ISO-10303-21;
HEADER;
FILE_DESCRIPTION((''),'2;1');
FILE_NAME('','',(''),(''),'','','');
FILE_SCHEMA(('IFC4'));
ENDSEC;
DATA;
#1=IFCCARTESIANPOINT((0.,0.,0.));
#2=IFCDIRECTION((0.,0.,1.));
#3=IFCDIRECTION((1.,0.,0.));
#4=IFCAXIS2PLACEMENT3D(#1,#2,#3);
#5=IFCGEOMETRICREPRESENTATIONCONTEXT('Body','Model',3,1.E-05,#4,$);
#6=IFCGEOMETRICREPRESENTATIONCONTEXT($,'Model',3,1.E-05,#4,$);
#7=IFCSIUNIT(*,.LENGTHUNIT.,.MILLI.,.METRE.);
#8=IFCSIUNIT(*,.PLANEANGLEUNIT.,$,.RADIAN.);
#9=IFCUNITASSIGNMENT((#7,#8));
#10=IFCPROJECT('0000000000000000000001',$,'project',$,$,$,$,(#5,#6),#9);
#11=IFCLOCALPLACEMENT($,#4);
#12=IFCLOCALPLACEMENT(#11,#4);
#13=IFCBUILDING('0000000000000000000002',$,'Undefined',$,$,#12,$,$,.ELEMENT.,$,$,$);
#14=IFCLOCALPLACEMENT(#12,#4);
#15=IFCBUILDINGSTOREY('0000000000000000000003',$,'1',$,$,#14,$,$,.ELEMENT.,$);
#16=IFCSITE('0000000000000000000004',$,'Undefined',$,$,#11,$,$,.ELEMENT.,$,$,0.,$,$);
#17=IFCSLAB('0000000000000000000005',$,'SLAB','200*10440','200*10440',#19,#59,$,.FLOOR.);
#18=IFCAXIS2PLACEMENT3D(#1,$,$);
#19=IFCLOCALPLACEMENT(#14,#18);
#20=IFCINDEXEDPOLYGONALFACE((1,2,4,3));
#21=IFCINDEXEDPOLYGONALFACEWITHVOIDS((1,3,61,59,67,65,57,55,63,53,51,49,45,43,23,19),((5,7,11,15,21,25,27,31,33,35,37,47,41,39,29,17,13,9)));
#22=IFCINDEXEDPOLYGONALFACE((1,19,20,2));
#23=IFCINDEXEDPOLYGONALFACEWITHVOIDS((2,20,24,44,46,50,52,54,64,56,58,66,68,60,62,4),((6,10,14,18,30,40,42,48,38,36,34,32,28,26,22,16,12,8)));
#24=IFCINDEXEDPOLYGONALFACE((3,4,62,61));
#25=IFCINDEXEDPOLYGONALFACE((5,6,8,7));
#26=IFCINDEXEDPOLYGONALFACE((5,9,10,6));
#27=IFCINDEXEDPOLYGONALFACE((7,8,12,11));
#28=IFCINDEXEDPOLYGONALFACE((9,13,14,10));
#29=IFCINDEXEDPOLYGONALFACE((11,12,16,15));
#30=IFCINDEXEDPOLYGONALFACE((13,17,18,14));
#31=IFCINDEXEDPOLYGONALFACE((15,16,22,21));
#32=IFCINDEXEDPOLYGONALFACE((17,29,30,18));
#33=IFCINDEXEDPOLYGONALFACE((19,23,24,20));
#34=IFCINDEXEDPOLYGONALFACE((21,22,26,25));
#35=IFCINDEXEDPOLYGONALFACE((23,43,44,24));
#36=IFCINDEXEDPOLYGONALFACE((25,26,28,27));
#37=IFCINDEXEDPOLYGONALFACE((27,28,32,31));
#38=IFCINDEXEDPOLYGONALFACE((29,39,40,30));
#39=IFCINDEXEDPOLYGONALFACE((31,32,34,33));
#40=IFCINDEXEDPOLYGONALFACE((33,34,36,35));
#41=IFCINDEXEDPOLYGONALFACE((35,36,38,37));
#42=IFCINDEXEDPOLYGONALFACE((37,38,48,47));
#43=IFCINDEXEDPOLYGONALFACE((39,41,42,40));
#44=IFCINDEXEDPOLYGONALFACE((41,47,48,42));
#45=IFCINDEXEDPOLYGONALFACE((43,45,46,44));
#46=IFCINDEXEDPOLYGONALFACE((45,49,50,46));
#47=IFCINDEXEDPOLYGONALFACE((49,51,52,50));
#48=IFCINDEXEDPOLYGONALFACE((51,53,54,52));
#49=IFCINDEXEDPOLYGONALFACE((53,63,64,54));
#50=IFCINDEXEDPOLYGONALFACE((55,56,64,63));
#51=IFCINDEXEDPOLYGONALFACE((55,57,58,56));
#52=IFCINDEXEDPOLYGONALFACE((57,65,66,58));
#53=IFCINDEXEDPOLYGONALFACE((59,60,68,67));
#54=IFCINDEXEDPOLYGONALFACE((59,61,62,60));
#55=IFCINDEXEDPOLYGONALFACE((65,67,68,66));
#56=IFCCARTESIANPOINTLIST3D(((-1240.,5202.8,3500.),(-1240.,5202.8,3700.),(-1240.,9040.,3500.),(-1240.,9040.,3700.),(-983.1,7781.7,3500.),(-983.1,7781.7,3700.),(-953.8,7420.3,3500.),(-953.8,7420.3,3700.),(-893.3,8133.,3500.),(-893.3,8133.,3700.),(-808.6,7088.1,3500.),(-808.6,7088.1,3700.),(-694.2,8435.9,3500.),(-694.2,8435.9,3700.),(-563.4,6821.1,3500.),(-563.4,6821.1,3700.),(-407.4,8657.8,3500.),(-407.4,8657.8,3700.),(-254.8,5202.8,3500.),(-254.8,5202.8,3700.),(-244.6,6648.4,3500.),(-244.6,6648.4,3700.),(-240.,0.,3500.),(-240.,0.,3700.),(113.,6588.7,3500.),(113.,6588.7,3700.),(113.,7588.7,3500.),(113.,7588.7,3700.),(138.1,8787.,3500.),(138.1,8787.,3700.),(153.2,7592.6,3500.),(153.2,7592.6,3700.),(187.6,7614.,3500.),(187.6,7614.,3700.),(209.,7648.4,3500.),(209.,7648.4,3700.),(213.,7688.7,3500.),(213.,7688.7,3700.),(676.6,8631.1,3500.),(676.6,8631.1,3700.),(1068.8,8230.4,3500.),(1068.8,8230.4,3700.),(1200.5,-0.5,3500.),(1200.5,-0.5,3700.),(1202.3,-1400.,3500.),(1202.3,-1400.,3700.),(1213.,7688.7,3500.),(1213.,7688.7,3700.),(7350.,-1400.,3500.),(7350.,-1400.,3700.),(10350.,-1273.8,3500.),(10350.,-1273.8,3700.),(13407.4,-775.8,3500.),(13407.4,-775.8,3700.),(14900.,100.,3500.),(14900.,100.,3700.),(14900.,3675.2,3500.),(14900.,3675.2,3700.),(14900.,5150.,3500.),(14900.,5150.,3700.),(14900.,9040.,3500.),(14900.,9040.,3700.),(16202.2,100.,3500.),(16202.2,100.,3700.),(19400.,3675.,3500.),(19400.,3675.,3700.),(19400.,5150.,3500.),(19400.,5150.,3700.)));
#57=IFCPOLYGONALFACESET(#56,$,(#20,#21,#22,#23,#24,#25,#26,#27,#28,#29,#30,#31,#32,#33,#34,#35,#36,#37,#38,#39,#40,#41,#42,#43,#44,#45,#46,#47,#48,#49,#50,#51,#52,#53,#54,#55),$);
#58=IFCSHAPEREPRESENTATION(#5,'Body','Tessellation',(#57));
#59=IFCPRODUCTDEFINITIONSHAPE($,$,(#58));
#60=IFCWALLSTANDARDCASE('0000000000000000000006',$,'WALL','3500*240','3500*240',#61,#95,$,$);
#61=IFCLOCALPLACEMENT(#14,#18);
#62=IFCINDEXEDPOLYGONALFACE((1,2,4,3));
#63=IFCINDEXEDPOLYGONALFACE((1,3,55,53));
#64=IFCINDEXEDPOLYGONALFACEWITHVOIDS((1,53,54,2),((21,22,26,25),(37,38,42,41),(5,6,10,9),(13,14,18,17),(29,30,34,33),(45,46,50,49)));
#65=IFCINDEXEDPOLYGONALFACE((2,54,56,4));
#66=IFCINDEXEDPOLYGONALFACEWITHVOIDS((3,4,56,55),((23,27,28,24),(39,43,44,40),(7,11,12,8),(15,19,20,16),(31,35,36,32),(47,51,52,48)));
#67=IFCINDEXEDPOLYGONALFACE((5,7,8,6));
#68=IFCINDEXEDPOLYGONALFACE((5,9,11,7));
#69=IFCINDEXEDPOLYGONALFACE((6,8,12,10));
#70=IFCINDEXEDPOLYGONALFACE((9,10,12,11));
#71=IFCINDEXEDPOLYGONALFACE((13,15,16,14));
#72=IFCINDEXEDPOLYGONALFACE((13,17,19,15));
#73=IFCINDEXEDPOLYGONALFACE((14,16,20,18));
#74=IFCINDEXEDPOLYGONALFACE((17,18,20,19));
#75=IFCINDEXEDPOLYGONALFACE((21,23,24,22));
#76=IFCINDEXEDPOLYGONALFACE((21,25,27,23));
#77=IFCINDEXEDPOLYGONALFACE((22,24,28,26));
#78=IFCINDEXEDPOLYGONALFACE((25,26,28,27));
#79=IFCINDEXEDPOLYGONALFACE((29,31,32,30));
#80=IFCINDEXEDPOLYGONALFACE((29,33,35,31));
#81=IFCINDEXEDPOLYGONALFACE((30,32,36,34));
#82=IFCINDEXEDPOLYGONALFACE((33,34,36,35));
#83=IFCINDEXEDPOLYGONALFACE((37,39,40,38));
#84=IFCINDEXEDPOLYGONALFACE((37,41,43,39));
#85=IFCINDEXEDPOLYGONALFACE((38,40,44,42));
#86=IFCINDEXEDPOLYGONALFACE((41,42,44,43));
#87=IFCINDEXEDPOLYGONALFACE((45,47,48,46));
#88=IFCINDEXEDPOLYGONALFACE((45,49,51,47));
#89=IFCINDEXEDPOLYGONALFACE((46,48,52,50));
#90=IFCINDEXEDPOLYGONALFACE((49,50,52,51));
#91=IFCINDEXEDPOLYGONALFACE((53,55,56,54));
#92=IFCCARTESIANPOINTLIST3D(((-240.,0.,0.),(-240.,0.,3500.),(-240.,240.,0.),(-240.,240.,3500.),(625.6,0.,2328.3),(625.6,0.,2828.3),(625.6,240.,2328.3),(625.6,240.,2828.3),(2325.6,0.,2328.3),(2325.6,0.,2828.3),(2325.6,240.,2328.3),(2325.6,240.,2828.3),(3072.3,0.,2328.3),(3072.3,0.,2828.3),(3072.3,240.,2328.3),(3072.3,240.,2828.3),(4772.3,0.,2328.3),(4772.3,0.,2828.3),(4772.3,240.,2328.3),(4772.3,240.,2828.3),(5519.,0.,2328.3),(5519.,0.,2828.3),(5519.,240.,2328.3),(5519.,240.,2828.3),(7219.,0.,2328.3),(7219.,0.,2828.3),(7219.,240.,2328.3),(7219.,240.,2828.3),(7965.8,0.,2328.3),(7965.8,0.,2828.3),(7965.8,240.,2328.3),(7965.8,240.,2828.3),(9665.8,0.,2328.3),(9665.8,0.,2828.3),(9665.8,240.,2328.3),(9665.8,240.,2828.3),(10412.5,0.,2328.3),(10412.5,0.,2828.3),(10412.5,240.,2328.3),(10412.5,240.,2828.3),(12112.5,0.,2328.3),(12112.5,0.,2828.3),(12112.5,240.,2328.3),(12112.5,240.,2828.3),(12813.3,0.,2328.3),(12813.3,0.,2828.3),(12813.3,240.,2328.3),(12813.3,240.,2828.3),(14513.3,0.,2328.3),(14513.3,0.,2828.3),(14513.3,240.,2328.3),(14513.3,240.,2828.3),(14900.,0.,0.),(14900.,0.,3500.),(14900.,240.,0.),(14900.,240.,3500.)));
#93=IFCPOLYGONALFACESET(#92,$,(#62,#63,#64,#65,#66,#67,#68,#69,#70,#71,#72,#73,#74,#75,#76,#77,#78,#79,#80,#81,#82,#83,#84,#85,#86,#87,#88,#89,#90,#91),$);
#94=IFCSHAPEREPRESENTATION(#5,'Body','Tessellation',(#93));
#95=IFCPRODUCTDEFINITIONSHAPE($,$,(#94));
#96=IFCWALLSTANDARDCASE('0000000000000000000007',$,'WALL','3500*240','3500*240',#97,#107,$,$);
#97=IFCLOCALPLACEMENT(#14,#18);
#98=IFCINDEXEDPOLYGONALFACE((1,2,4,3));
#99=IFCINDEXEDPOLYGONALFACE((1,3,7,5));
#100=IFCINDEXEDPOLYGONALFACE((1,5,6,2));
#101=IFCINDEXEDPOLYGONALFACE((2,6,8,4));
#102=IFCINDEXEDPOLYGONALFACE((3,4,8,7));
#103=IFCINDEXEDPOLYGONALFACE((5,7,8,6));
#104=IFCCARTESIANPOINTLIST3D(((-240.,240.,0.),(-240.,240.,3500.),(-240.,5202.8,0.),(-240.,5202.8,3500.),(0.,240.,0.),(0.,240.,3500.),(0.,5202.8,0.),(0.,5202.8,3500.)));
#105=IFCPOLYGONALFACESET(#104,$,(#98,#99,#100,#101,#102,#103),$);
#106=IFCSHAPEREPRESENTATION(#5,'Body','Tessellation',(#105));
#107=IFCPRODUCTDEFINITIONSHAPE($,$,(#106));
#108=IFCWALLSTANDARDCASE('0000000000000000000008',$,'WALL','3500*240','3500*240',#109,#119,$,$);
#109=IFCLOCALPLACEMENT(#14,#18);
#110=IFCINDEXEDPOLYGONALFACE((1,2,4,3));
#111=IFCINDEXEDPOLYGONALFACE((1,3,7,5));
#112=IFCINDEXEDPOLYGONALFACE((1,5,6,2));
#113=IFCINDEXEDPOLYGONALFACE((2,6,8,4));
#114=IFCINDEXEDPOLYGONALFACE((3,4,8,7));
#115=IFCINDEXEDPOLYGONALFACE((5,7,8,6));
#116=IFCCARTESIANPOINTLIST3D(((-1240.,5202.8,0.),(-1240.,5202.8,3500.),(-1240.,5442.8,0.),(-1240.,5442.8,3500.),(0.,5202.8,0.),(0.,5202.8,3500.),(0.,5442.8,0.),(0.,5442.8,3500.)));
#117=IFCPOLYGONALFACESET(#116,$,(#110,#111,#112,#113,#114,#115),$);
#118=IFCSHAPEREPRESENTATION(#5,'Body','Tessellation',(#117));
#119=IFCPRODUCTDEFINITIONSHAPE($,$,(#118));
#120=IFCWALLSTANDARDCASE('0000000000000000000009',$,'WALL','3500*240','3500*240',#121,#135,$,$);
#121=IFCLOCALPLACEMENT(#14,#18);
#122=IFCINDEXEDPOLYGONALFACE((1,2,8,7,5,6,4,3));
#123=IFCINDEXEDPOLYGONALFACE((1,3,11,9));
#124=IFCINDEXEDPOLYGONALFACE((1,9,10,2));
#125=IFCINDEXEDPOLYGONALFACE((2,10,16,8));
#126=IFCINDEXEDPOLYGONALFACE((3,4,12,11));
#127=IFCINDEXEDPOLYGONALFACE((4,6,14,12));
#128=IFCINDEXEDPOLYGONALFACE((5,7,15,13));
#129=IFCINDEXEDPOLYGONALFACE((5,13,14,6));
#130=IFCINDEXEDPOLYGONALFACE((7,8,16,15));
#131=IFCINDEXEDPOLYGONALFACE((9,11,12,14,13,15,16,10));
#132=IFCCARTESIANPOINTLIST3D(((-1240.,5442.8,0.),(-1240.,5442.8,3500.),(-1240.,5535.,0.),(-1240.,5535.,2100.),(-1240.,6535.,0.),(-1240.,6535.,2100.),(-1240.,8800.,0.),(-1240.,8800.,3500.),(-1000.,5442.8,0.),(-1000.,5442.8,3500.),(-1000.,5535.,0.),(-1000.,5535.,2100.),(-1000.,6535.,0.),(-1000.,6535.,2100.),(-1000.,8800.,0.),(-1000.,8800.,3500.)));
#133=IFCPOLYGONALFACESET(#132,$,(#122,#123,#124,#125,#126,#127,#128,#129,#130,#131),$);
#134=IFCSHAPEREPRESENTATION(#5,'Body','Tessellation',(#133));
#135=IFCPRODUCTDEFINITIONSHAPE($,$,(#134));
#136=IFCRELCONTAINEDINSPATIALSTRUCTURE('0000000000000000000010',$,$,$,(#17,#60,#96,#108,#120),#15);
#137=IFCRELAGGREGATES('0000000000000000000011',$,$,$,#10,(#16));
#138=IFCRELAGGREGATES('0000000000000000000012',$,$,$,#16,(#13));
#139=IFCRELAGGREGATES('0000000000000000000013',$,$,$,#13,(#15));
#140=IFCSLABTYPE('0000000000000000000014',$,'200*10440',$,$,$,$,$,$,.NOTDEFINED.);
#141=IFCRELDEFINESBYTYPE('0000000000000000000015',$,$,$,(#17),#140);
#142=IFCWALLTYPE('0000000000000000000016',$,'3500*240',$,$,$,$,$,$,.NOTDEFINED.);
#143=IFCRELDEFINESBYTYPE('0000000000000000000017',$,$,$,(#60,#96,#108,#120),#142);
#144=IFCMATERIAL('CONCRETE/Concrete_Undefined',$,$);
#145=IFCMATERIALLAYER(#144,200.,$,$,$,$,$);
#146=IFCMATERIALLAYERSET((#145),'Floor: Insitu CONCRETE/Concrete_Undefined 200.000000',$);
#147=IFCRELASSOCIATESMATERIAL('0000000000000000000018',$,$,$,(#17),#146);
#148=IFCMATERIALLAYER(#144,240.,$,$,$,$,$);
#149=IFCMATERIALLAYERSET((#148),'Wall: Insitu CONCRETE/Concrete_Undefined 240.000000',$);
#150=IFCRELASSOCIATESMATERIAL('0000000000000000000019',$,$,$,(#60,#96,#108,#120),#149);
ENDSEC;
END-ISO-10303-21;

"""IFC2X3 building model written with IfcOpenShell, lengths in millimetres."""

from ifc_helpers import new_model, si_unit, frame, frame_2d, origin_with_axes, place, context, project, spatial, polyline, rectangle, outline, extrude, material, layer, layer_set, layer_usage, type_object, element, save


model = new_model("IFC2X3")

# Units and contexts
model_context_1 = context("Model", 3, precision=1e-05, world=origin_with_axes(), identifier="Body")
model_context_2 = context("Model", 3, precision=1e-05, world=origin_with_axes())
ifc_project = project(units=[si_unit("LENGTHUNIT", "METRE", prefix="MILLI"), si_unit("PLANEANGLEUNIT", "RADIAN")], contexts=[model_context_1, model_context_2])

# Site, building, storey
site_placement = place(None, origin_with_axes())
site = spatial("IfcSite", under=ifc_project, at=site_placement, Name="Undefined", CompositionType="ELEMENT", RefElevation=0.0)
building_placement = place(site_placement, origin_with_axes())
building = spatial("IfcBuilding", under=site, at=building_placement, Name="Undefined", CompositionType="ELEMENT")
storey_placement = place(building_placement, origin_with_axes())
storey = spatial("IfcBuildingStorey", under=building, at=storey_placement, Name="1", CompositionType="ELEMENT")

# Shared definitions
ifc_material = material(Name="CONCRETE/Concrete_Undefined")

# Slab, opening
ifc_layer_1 = layer(ifc_material, 200.0)
ifc_layer_set_1 = layer_set([ifc_layer_1], Name="Floor: Insitu CONCRETE/Concrete_Undefined 200.000000")
ifc_layer_usage_1 = layer_usage(ifc_layer_set_1, "AXIS3", "POSITIVE", -100.0)
slab_type_1 = type_object("IfcSlabType", Name="200*10440", PredefinedType="NOTDEFINED")
slab_1_placement = place(storey_placement, frame((-1240.0, 9040.0, 3600.0), z_axis=(0.0, 0.0, 1.0), x_axis=(0.0, -1.0, 0.0)))
slab_1 = element("IfcSlab", 1, at=slab_1_placement, inside=storey, type_object=slab_type_1, material=ifc_layer_usage_1, Name="SLAB", Description="200*10440", ObjectType="200*10440", PredefinedType="FLOOR", context=model_context_1, shape_type="SweptSolid", body=[
    extrude(outline(polyline([(0.0, 0.0), (3837.2, 0.0), (3837.2, 985.2), (9040.0, 1000.0), (9040.5, 2440.5), (10440.0, 2442.3), (10440.0, 8590.0), (10313.8, 11590.0), (9815.8, 14647.4), (8940.0, 17442.2), (8940.0, 16140.0), (5364.8, 16140.0), (5365.0, 20640.0), (3890.0, 20640.0), (3890.0, 16140.0), (0.0, 16140.0), (0.0, 0.0)])), frame((0.0, 0.0, -100.0), z_axis=(0.0, 0.0, 1.0), x_axis=(1.0, 0.0, 0.0)), (0.0, 0.0, 1.0), 200.0),
])
opening_1_placement = place(storey_placement, frame((-1240.0, 9040.0, 3600.0), z_axis=(0.0, 0.0, 1.0), x_axis=(0.0, -1.0, 0.0)))
element("IfcOpeningElement", 2, at=opening_1_placement, cuts=slab_1, ObjectType="Recess", context=model_context_1, shape_type="SweptSolid", body=[
    extrude(outline(polyline([(0.0, 0.0), (1000.0, 0.0), (940.3, 357.6), (767.5, 676.3), (500.5, 921.6), (168.3, 1066.8), (-193.1, 1096.1), (-544.3, 1006.3), (-847.3, 807.2), (-1069.1, 520.4), (-1198.4, -25.1), (-1042.5, -563.7), (-641.8, -955.8), (-100.0, -1100.0), (-100.0, -100.0), (-59.7, -96.0), (-25.4, -74.6), (-4.0, -40.3), (0.0, 0.0)])), frame((1451.3, 1353.0, 102.5), z_axis=(0.0, 0.0, -1.0), x_axis=(1.0, 0.0, 0.0)), (0.0, 0.0, 1.0), 205.0),
])

# Wall, openings
ifc_layer_2 = layer(ifc_material, 240.0)
ifc_layer_set_2 = layer_set([ifc_layer_2], Name="Wall: Insitu CONCRETE/Concrete_Undefined 240.000000")
ifc_layer_usage_2 = layer_usage(ifc_layer_set_2, "AXIS2", "POSITIVE", -120.0)
wall_type_1 = type_object("IfcWallType", Name="3500*240", PredefinedType="NOTDEFINED")
wall_1_placement = place(storey_placement, frame((-240.0, 120.0, 0.0), z_axis=(0.0, 0.0, 1.0), x_axis=(1.0, 0.0, 0.0)))
wall_1 = element("IfcWallStandardCase", 3, at=wall_1_placement, inside=storey, type_object=wall_type_1, material=ifc_layer_usage_2, Name="WALL", Description="3500*240", ObjectType="3500*240", context=model_context_1, shape_type="SweptSolid", body=[
    extrude(rectangle(XDim=15140.0, YDim=240.0, at=frame_2d((0.0, 7570.0), x_axis=(0.0, -1.0))), frame((0.0, 0.0, 0.0), z_axis=(0.0, 0.0, 1.0), x_axis=(0.0, -1.0, 0.0)), (0.0, 0.0, 1.0), 3500.0),
])
opening_2_placement = place(storey_placement, frame((-240.0, 120.0, 0.0), z_axis=(0.0, 0.0, 1.0), x_axis=(1.0, 0.0, 0.0)))
element("IfcOpeningElement", 4, at=opening_2_placement, cuts=wall_1, ObjectType="Recess", context=model_context_1, shape_type="SweptSolid", body=[
    extrude(outline(polyline([(0.0, 0.0), (500.0, 0.0), (500.0, 1700.0), (0.0, 1700.0), (0.0, 0.0)])), frame((865.6, 122.5, 2828.3), z_axis=(0.0, -1.0, 0.0), x_axis=(0.0, 0.0, -1.0)), (0.0, 0.0, 1.0), 245.0),
])
opening_3_placement = place(storey_placement, frame((-240.0, 120.0, 0.0), z_axis=(0.0, 0.0, 1.0), x_axis=(1.0, 0.0, 0.0)))
element("IfcOpeningElement", 5, at=opening_3_placement, cuts=wall_1, ObjectType="Recess", context=model_context_1, shape_type="SweptSolid", body=[
    extrude(outline(polyline([(0.0, 0.0), (500.0, 0.0), (500.0, 1700.0), (0.0, 1700.0), (0.0, 0.0)])), frame((865.6, 122.5, 2828.3), z_axis=(0.0, -1.0, 0.0), x_axis=(0.0, 0.0, -1.0)), (0.0, 0.0, 1.0), 245.0),
])
opening_4_placement = place(storey_placement, frame((-240.0, 120.0, 0.0), z_axis=(0.0, 0.0, 1.0), x_axis=(1.0, 0.0, 0.0)))
element("IfcOpeningElement", 6, at=opening_4_placement, cuts=wall_1, ObjectType="Recess", context=model_context_1, shape_type="SweptSolid", body=[
    extrude(outline(polyline([(0.0, 0.0), (500.0, 0.0), (500.0, 1700.0), (0.0, 1700.0), (0.0, 0.0)])), frame((3312.3, 122.5, 2828.3), z_axis=(0.0, -1.0, 0.0), x_axis=(0.0, 0.0, -1.0)), (0.0, 0.0, 1.0), 245.0),
])
opening_5_placement = place(storey_placement, frame((-240.0, 120.0, 0.0), z_axis=(0.0, 0.0, 1.0), x_axis=(1.0, 0.0, 0.0)))
element("IfcOpeningElement", 7, at=opening_5_placement, cuts=wall_1, ObjectType="Recess", context=model_context_1, shape_type="SweptSolid", body=[
    extrude(outline(polyline([(0.0, 0.0), (500.0, 0.0), (500.0, 1700.0), (0.0, 1700.0), (0.0, 0.0)])), frame((5759.0, 122.5, 2828.3), z_axis=(0.0, -1.0, 0.0), x_axis=(0.0, 0.0, -1.0)), (0.0, 0.0, 1.0), 245.0),
])
opening_6_placement = place(storey_placement, frame((-240.0, 120.0, 0.0), z_axis=(0.0, 0.0, 1.0), x_axis=(1.0, 0.0, 0.0)))
element("IfcOpeningElement", 8, at=opening_6_placement, cuts=wall_1, ObjectType="Recess", context=model_context_1, shape_type="SweptSolid", body=[
    extrude(outline(polyline([(0.0, 0.0), (500.0, 0.0), (500.0, 1700.0), (0.0, 1700.0), (0.0, 0.0)])), frame((8205.8, 122.5, 2828.3), z_axis=(0.0, -1.0, 0.0), x_axis=(0.0, 0.0, -1.0)), (0.0, 0.0, 1.0), 245.0),
])
opening_7_placement = place(storey_placement, frame((-240.0, 120.0, 0.0), z_axis=(0.0, 0.0, 1.0), x_axis=(1.0, 0.0, 0.0)))
element("IfcOpeningElement", 9, at=opening_7_placement, cuts=wall_1, ObjectType="Recess", context=model_context_1, shape_type="SweptSolid", body=[
    extrude(outline(polyline([(0.0, 0.0), (1700.0, 0.0), (1700.0, 500.0), (0.0, 500.0), (0.0, 0.0)])), frame((10652.5, -122.5, 2828.3), z_axis=(0.0, 1.0, 0.0), x_axis=(1.0, 0.0, 0.0)), (0.0, 0.0, 1.0), 245.0),
])
opening_8_placement = place(storey_placement, frame((-240.0, 120.0, 0.0), z_axis=(0.0, 0.0, 1.0), x_axis=(1.0, 0.0, 0.0)))
element("IfcOpeningElement", 10, at=opening_8_placement, cuts=wall_1, ObjectType="Recess", context=model_context_1, shape_type="SweptSolid", body=[
    extrude(outline(polyline([(0.0, 0.0), (500.0, 0.0), (500.0, 1700.0), (0.0, 1700.0), (0.0, 0.0)])), frame((13053.3, 122.5, 2828.3), z_axis=(0.0, -1.0, 0.0), x_axis=(0.0, 0.0, -1.0)), (0.0, 0.0, 1.0), 245.0),
])

# Walls
ifc_layer_usage_3 = layer_usage(ifc_layer_set_2, "AXIS2", "POSITIVE", -120.0)
wall_2_placement = place(storey_placement, frame((-120.0, 240.0, 0.0), z_axis=(0.0, 0.0, 1.0), x_axis=(0.0, 1.0, 0.0)))
element("IfcWallStandardCase", 11, at=wall_2_placement, inside=storey, type_object=wall_type_1, material=ifc_layer_usage_3, Name="WALL", Description="3500*240", ObjectType="3500*240", context=model_context_1, shape_type="SweptSolid", body=[
    extrude(rectangle(XDim=4962.8, YDim=240.0, at=frame_2d((0.0, 2481.4), x_axis=(0.0, -1.0))), frame((0.0, 0.0, 0.0), z_axis=(0.0, 0.0, 1.0), x_axis=(0.0, -1.0, 0.0)), (0.0, 0.0, 1.0), 3500.0),
])
ifc_layer_usage_4 = layer_usage(ifc_layer_set_2, "AXIS2", "POSITIVE", -120.0)
wall_3_placement = place(storey_placement, frame((0.0, 5322.8, 0.0), z_axis=(0.0, 0.0, 1.0), x_axis=(-1.0, 0.0, 0.0)))
element("IfcWallStandardCase", 12, at=wall_3_placement, inside=storey, type_object=wall_type_1, material=ifc_layer_usage_4, Name="WALL", Description="3500*240", ObjectType="3500*240", context=model_context_1, shape_type="SweptSolid", body=[
    extrude(rectangle(XDim=1240.0, YDim=240.0, at=frame_2d((0.0, 620.0), x_axis=(0.0, -1.0))), frame((0.0, 0.0, 0.0), z_axis=(0.0, 0.0, 1.0), x_axis=(0.0, -1.0, 0.0)), (0.0, 0.0, 1.0), 3500.0),
])

# Wall, opening
ifc_layer_usage_5 = layer_usage(ifc_layer_set_2, "AXIS2", "POSITIVE", -120.0)
wall_4_placement = place(storey_placement, frame((-1120.0, 5442.8, 0.0), z_axis=(0.0, 0.0, 1.0), x_axis=(0.0, 1.0, 0.0)))
wall_4 = element("IfcWallStandardCase", 13, at=wall_4_placement, inside=storey, type_object=wall_type_1, material=ifc_layer_usage_5, Name="WALL", Description="3500*240", ObjectType="3500*240", context=model_context_1, shape_type="SweptSolid", body=[
    extrude(rectangle(XDim=3357.2, YDim=240.0, at=frame_2d((0.0, 1678.6), x_axis=(0.0, -1.0))), frame((0.0, 0.0, 0.0), z_axis=(0.0, 0.0, 1.0), x_axis=(0.0, -1.0, 0.0)), (0.0, 0.0, 1.0), 3500.0),
])
opening_9_placement = place(storey_placement, frame((-1120.0, 5442.8, 0.0), z_axis=(0.0, 0.0, 1.0), x_axis=(0.0, 1.0, 0.0)))
element("IfcOpeningElement", 14, at=opening_9_placement, cuts=wall_4, ObjectType="Recess", context=model_context_1, shape_type="SweptSolid", body=[
    extrude(outline(polyline([(0.0, 0.0), (1000.0, 0.0), (1000.0, 2100.0), (0.0, 2100.0), (0.0, 0.0)])), frame((1092.2, 123.0, 2100.0), z_axis=(0.0, -1.0, 0.0), x_axis=(-1.0, 0.0, 0.0)), (0.0, 0.0, 1.0), 246.0),
])

save(model, "model.ifc")
